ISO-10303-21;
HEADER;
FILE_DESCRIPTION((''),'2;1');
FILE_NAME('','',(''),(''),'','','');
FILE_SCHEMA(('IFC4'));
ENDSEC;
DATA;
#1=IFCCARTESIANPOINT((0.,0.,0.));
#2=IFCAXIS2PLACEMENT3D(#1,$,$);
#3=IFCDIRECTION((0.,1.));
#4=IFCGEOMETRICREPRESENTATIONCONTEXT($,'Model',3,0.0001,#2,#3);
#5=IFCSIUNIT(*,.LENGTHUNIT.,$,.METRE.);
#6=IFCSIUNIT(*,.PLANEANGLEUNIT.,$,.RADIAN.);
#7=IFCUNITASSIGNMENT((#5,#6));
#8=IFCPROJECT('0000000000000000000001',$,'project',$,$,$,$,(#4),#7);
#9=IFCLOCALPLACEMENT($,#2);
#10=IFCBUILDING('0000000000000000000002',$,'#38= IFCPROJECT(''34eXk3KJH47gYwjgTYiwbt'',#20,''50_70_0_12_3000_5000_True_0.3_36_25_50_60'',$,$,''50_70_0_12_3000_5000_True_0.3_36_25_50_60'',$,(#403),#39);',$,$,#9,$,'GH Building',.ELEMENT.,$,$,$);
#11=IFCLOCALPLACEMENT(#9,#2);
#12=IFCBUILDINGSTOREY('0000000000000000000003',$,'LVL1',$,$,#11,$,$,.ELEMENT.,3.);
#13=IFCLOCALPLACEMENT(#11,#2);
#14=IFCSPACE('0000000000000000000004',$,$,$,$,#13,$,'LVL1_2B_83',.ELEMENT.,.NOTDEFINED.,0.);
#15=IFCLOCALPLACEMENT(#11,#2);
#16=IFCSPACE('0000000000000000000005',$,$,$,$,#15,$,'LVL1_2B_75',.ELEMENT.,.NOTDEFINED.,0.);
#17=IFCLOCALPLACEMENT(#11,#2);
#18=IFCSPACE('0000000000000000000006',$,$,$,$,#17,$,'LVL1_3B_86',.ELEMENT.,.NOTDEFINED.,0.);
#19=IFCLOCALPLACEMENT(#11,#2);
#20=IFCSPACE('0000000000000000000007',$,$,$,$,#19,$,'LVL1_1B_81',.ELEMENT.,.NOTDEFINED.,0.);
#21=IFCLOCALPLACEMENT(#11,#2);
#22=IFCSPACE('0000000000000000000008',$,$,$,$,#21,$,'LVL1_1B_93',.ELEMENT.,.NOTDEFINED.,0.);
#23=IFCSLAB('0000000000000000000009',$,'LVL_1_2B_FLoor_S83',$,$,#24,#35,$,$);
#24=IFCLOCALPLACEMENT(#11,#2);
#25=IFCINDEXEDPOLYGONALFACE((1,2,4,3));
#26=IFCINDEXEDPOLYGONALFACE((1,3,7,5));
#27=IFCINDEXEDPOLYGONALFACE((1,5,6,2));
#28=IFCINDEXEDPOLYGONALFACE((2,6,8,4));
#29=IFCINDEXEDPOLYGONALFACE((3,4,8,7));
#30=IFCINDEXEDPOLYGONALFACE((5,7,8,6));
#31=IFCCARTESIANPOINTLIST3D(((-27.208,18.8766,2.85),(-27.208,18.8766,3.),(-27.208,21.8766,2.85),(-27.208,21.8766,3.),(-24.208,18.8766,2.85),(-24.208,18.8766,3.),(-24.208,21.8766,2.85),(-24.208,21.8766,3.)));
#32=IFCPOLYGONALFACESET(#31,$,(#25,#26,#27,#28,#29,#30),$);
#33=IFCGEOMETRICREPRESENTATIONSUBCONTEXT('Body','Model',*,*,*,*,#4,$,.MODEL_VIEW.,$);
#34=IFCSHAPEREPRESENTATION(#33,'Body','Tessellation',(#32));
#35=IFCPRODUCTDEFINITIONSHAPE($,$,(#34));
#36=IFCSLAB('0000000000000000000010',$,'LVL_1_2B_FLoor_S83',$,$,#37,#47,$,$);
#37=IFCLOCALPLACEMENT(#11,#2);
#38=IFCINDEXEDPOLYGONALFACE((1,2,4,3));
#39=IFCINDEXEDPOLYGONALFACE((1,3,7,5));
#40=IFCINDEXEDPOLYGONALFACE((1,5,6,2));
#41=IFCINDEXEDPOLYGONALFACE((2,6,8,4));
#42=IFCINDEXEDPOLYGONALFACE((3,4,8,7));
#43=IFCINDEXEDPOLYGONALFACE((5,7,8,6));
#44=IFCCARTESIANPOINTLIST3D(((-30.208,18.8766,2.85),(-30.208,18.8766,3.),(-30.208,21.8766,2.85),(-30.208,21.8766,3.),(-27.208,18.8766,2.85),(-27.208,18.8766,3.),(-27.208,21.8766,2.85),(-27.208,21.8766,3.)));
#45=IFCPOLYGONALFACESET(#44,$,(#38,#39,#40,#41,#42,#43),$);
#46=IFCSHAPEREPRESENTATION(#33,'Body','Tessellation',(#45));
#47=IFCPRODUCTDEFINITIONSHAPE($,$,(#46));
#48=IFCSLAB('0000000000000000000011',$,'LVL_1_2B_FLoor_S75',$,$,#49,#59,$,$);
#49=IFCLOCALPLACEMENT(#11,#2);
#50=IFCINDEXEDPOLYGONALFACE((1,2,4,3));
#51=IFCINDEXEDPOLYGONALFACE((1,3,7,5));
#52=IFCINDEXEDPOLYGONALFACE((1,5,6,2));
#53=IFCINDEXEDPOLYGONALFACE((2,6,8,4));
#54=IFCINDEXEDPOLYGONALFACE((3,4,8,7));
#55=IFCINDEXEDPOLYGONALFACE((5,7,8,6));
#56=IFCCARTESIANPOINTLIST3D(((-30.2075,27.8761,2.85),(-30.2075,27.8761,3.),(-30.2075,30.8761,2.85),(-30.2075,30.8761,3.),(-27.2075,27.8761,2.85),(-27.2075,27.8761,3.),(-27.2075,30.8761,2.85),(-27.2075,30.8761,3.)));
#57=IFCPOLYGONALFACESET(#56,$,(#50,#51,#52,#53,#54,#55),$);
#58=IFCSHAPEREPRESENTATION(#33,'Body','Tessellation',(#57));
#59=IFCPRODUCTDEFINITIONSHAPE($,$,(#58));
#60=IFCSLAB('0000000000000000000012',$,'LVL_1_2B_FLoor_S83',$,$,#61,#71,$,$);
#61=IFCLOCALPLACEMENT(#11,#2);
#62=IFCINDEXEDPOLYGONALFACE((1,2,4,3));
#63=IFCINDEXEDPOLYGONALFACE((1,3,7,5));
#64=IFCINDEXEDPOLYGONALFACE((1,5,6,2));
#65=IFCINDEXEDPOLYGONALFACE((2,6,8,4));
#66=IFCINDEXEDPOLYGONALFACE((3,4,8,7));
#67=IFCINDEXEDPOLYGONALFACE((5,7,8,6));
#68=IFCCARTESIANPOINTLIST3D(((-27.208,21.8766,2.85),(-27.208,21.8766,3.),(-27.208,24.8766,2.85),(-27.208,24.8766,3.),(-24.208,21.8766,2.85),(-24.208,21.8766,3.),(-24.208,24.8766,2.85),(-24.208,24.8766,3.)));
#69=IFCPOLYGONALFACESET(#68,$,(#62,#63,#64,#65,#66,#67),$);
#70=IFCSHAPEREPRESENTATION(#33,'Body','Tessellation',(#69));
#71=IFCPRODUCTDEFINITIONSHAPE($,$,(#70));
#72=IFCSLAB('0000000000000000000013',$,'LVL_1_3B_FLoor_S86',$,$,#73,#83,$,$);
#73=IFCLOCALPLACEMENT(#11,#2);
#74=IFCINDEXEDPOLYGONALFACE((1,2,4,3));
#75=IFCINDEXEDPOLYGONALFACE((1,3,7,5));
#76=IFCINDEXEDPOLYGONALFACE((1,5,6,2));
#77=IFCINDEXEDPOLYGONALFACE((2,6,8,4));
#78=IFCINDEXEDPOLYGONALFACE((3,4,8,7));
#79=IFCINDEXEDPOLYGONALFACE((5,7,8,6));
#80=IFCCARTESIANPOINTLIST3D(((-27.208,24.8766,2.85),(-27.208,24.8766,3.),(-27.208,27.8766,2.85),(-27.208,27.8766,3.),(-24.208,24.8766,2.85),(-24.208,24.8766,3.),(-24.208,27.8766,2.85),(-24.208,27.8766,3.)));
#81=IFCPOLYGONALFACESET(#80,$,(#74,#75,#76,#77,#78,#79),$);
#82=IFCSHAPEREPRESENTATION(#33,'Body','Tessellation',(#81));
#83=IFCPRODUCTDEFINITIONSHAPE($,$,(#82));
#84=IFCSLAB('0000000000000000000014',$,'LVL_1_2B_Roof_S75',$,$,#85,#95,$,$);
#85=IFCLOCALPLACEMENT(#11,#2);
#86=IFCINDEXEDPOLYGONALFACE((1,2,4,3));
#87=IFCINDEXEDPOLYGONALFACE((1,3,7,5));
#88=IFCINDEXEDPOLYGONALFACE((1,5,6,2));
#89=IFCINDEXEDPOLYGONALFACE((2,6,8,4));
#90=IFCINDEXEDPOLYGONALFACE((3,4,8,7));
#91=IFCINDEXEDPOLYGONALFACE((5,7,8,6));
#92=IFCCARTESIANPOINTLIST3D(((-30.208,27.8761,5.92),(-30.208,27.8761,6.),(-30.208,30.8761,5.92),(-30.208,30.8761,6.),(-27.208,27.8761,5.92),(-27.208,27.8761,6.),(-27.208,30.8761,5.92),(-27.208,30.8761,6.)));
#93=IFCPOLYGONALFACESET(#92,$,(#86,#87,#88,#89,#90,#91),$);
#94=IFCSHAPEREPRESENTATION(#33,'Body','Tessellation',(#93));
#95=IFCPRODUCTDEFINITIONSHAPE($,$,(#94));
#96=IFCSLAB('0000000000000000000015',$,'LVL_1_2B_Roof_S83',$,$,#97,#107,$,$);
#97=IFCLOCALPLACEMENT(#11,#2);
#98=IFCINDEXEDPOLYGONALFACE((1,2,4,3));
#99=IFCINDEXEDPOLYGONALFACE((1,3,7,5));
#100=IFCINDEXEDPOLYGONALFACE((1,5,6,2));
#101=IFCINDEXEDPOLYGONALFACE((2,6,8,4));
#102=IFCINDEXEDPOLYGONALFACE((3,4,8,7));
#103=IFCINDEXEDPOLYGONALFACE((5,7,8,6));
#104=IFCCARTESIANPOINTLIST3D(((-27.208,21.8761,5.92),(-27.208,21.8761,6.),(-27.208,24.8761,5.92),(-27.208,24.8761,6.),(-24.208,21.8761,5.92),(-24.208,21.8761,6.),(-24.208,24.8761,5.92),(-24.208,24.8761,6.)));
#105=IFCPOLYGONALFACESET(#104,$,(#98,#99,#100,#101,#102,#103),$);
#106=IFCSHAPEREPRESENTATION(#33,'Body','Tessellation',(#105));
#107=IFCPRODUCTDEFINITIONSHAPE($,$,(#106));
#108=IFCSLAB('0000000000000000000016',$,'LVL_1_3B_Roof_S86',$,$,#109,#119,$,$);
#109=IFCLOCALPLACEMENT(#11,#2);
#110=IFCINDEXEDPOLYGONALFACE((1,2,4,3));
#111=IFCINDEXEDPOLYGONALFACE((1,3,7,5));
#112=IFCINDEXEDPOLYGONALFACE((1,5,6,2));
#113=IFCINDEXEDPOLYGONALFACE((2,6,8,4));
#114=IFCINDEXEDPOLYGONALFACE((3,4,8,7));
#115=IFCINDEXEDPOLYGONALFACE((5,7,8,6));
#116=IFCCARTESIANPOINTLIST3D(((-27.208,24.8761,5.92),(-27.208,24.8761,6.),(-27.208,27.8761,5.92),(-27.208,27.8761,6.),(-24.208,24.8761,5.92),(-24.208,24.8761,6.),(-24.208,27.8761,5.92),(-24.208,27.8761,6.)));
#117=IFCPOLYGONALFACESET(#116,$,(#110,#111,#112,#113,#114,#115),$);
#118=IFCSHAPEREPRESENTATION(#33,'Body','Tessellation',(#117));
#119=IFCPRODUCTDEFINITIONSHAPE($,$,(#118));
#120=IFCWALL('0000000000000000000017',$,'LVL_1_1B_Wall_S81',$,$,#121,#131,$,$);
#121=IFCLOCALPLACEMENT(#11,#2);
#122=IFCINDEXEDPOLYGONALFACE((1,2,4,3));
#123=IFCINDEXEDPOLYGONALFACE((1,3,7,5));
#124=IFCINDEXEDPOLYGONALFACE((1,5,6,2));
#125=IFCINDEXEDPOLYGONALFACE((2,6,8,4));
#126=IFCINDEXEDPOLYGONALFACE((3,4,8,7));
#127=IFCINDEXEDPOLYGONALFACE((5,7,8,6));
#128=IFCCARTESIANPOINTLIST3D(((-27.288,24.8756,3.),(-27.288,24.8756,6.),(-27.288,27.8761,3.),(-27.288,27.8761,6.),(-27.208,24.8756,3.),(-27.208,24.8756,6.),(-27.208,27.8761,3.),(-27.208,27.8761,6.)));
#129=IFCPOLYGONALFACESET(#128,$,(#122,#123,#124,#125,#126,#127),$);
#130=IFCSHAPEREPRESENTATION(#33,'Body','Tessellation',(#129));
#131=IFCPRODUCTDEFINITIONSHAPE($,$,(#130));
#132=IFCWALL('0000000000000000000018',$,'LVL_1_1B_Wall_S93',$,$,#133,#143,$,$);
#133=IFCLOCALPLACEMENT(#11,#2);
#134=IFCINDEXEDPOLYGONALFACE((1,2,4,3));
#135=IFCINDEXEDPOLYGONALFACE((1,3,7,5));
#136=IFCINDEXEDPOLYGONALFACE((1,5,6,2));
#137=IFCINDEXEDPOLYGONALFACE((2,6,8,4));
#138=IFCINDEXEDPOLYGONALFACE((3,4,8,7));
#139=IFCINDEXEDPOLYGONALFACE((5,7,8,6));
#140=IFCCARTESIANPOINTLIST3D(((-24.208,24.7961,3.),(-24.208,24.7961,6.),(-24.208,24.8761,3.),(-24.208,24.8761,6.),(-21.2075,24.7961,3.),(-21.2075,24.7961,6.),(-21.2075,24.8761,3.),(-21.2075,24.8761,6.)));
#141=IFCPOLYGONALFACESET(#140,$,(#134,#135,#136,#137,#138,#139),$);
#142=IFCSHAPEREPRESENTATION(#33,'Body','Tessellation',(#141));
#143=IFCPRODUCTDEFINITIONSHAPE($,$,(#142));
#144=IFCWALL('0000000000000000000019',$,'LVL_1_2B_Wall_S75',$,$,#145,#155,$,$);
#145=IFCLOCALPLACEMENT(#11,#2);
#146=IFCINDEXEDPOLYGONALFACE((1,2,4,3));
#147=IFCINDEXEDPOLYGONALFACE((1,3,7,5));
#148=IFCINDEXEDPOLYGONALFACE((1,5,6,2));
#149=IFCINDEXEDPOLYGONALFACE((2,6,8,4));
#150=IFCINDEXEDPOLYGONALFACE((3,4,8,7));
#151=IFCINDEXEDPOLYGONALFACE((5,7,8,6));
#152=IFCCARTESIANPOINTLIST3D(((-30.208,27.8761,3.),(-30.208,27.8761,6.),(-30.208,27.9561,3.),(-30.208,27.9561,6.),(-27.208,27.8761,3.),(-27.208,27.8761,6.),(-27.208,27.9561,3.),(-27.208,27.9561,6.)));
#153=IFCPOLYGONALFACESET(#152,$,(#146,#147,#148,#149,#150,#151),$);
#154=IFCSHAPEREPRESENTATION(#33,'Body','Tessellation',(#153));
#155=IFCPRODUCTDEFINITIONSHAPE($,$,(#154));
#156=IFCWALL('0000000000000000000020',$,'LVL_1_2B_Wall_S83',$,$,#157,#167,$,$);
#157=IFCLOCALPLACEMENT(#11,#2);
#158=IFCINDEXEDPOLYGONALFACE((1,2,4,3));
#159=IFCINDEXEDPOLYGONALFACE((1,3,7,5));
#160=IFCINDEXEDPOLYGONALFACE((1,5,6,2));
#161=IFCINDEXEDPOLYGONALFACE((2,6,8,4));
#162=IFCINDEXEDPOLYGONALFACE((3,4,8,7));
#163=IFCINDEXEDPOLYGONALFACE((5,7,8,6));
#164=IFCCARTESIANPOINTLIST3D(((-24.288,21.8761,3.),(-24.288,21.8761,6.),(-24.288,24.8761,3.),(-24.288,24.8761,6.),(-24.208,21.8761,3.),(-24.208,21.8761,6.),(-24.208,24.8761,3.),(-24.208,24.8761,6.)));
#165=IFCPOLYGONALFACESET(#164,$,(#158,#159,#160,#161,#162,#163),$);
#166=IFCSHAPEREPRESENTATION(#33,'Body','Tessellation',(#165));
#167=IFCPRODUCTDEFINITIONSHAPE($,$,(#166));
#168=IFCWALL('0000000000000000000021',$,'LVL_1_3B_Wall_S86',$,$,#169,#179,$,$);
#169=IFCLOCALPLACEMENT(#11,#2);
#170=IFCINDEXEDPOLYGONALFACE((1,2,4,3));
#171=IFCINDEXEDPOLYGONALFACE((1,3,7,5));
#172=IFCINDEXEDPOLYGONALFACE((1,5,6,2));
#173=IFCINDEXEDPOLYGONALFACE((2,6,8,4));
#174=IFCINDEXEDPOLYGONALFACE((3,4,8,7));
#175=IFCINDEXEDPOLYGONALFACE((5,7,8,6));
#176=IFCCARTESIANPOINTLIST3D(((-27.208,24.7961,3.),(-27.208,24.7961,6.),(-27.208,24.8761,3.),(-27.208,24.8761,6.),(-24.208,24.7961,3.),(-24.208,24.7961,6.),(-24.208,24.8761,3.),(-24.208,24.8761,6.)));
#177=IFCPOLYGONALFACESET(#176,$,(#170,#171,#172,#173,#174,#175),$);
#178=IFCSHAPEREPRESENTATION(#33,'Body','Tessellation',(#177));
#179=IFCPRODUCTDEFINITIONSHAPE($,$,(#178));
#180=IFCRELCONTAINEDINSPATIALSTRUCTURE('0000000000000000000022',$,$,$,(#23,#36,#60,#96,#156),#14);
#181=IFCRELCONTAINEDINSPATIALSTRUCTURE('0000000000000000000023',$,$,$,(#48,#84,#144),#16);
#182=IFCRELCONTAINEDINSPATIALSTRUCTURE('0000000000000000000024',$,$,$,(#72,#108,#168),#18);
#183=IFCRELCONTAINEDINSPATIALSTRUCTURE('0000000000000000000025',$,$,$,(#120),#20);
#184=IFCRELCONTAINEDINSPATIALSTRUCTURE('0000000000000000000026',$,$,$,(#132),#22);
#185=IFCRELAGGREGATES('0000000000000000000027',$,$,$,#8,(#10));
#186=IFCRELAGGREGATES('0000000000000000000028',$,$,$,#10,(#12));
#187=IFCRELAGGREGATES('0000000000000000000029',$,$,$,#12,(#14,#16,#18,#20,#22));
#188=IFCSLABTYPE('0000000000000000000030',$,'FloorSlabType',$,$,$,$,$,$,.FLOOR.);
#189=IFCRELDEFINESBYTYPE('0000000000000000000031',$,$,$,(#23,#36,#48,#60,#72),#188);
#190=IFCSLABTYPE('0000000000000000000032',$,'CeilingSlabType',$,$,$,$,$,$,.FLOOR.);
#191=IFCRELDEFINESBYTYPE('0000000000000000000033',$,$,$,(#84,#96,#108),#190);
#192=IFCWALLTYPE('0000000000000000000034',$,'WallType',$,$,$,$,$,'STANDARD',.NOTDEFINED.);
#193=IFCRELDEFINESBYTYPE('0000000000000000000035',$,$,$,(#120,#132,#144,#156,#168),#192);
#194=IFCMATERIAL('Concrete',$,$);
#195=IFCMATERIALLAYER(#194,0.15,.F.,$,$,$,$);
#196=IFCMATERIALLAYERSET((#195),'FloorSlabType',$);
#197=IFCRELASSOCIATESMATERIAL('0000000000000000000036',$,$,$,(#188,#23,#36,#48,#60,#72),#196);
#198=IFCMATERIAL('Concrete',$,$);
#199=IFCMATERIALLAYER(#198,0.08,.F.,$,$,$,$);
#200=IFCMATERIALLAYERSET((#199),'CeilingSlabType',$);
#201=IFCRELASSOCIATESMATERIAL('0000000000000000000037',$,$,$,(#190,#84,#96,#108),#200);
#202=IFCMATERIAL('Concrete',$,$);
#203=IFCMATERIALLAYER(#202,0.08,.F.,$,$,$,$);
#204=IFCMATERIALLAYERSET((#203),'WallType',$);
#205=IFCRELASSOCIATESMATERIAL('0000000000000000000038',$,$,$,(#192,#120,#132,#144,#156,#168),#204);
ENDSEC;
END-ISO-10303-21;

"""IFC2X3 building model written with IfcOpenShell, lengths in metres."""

from ifc_helpers import new_model, si_unit, direction, frame, frame_2d, origin, place, context, subcontext, project, spatial, rectangle, extrude, material, layer, layer_set, layer_usage, type_object, element, save


model = new_model("IFC2X3")

# Units and contexts
model_context = context("Model", 3, precision=0.0001, world=origin(), true_north=direction((0.0, 1.0)))
body_context = subcontext(model_context, "Body", "Model", "MODEL_VIEW")
ifc_project = project(units=[si_unit("LENGTHUNIT", "METRE"), si_unit("PLANEANGLEUNIT", "RADIAN")], contexts=[model_context])

# Building, storey, space
building_placement = place(None, origin())
building = spatial("IfcBuilding", under=ifc_project, at=building_placement, Name="#38= IFCPROJECT('34eXk3KJH47gYwjgTYiwbt',#20,'50_70_0_12_3000_5000_True_0.3_36_25_50_60',$,$,'50_70_0_12_3000_5000_True_0.3_36_25_50_60',$,(#403),#39);", LongName="GH Building", CompositionType="ELEMENT")
storey_placement = place(building_placement, origin())
storey = spatial("IfcBuildingStorey", under=building, at=storey_placement, Name="LVL1", CompositionType="ELEMENT", Elevation=3.0)
space_1_placement = place(storey_placement, origin())
space_1 = spatial("IfcSpace", under=storey, at=space_1_placement, LongName="LVL1_2B_83", CompositionType="ELEMENT", InteriorOrExteriorSpace="NOTDEFINED", ElevationWithFlooring=0.0)

# Slabs
ifc_material_1 = material(Name="Concrete")
ifc_layer_1 = layer(ifc_material_1, 0.15, ventilated=False)
ifc_layer_set_1 = layer_set([ifc_layer_1], Name="FloorSlabType")
ifc_layer_usage_1 = layer_usage(ifc_layer_set_1, "AXIS3", "NEGATIVE", -0.15)
slab_type_1 = type_object("IfcSlabType", Name="FloorSlabType", PredefinedType="FLOOR", material=ifc_layer_set_1)
slab_1_placement = place(space_1_placement, frame((-24.208, 21.8766, 2.85), z_axis=(0.0, 0.0, 1.0), x_axis=(-1.0, 0.0, 0.0)))
element("IfcSlab", 1, at=slab_1_placement, inside=space_1, type_object=slab_type_1, material=ifc_layer_usage_1, Name="LVL_1_2B_FLoor_S83", context=body_context, shape_type="SweptSolid", body=[
    extrude(rectangle(XDim=3.0, YDim=3.0, at=frame_2d((1.5, 1.5))), origin(), (0.0, 0.0, 1.0), 0.15),
])
ifc_layer_usage_2 = layer_usage(ifc_layer_set_1, "AXIS3", "NEGATIVE", -0.15)
slab_2_placement = place(space_1_placement, frame((-27.208, 21.8766, 2.85), z_axis=(0.0, 0.0, 1.0), x_axis=(-1.0, 0.0, 0.0)))
element("IfcSlab", 2, at=slab_2_placement, inside=space_1, type_object=slab_type_1, material=ifc_layer_usage_2, Name="LVL_1_2B_FLoor_S83", context=body_context, shape_type="SweptSolid", body=[
    extrude(rectangle(XDim=3.0, YDim=3.0, at=frame_2d((1.5, 1.5))), origin(), (0.0, 0.0, 1.0), 0.15),
])

# Shared definitions
space_2_placement = place(storey_placement, origin())
space_2 = spatial("IfcSpace", under=storey, at=space_2_placement, LongName="LVL1_2B_75", CompositionType="ELEMENT", InteriorOrExteriorSpace="NOTDEFINED", ElevationWithFlooring=0.0)

# Slabs
ifc_layer_usage_3 = layer_usage(ifc_layer_set_1, "AXIS3", "NEGATIVE", -0.15)
slab_3_placement = place(space_2_placement, frame((-27.2075, 27.8761, 2.85), z_axis=(0.0, 0.0, 1.0), x_axis=(0.0, 1.0, 0.0)))
element("IfcSlab", 3, at=slab_3_placement, inside=space_2, type_object=slab_type_1, material=ifc_layer_usage_3, Name="LVL_1_2B_FLoor_S75", context=body_context, shape_type="SweptSolid", body=[
    extrude(rectangle(XDim=3.0, YDim=3.0, at=frame_2d((1.5, 1.5))), origin(), (0.0, 0.0, 1.0), 0.15),
])
ifc_layer_usage_4 = layer_usage(ifc_layer_set_1, "AXIS3", "NEGATIVE", -0.15)
slab_4_placement = place(space_1_placement, frame((-24.208, 24.8766, 2.85), z_axis=(0.0, 0.0, 1.0), x_axis=(-1.0, 0.0, 0.0)))
element("IfcSlab", 4, at=slab_4_placement, inside=space_1, type_object=slab_type_1, material=ifc_layer_usage_4, Name="LVL_1_2B_FLoor_S83", context=body_context, shape_type="SweptSolid", body=[
    extrude(rectangle(XDim=3.0, YDim=3.0, at=frame_2d((1.5, 1.5))), origin(), (0.0, 0.0, 1.0), 0.15),
])

# Shared definitions
space_3_placement = place(storey_placement, origin())
space_3 = spatial("IfcSpace", under=storey, at=space_3_placement, LongName="LVL1_3B_86", CompositionType="ELEMENT", InteriorOrExteriorSpace="NOTDEFINED", ElevationWithFlooring=0.0)

# Slabs
ifc_layer_usage_5 = layer_usage(ifc_layer_set_1, "AXIS3", "NEGATIVE", -0.15)
slab_5_placement = place(space_3_placement, frame((-24.208, 27.8766, 2.85), z_axis=(0.0, 0.0, 1.0), x_axis=(-1.0, 0.0, 0.0)))
element("IfcSlab", 5, at=slab_5_placement, inside=space_3, type_object=slab_type_1, material=ifc_layer_usage_5, Name="LVL_1_3B_FLoor_S86", context=body_context, shape_type="SweptSolid", body=[
    extrude(rectangle(XDim=3.0, YDim=3.0, at=frame_2d((1.5, 1.5))), origin(), (0.0, 0.0, 1.0), 0.15),
])
ifc_material_2 = material(Name="Concrete")
ifc_layer_2 = layer(ifc_material_2, 0.08, ventilated=False)
ifc_layer_set_2 = layer_set([ifc_layer_2], Name="CeilingSlabType")
ifc_layer_usage_6 = layer_usage(ifc_layer_set_2, "AXIS3", "NEGATIVE", -0.08)
slab_type_2 = type_object("IfcSlabType", Name="CeilingSlabType", PredefinedType="FLOOR", material=ifc_layer_set_2)
slab_6_placement = place(space_2_placement, frame((-27.208, 27.8761, 5.92), z_axis=(0.0, 0.0, 1.0), x_axis=(0.0, 1.0, 0.0)))
element("IfcSlab", 6, at=slab_6_placement, inside=space_2, type_object=slab_type_2, material=ifc_layer_usage_6, Name="LVL_1_2B_Roof_S75", context=body_context, shape_type="SweptSolid", body=[
    extrude(rectangle(XDim=3.0, YDim=3.0, at=frame_2d((1.5, 1.5))), origin(), (0.0, 0.0, 1.0), 0.08),
])
ifc_layer_usage_7 = layer_usage(ifc_layer_set_2, "AXIS3", "NEGATIVE", -0.08)
slab_7_placement = place(space_1_placement, frame((-24.208, 24.8761, 5.92), z_axis=(0.0, 0.0, 1.0), x_axis=(-1.0, 0.0, 0.0)))
element("IfcSlab", 7, at=slab_7_placement, inside=space_1, type_object=slab_type_2, material=ifc_layer_usage_7, Name="LVL_1_2B_Roof_S83", context=body_context, shape_type="SweptSolid", body=[
    extrude(rectangle(XDim=3.0, YDim=3.0, at=frame_2d((1.5, 1.5))), origin(), (0.0, 0.0, 1.0), 0.08),
])
ifc_layer_usage_8 = layer_usage(ifc_layer_set_2, "AXIS3", "NEGATIVE", -0.08)
slab_8_placement = place(space_3_placement, frame((-27.208, 27.8761, 5.92)))
element("IfcSlab", 8, at=slab_8_placement, inside=space_3, type_object=slab_type_2, material=ifc_layer_usage_8, Name="LVL_1_3B_Roof_S86", context=body_context, shape_type="SweptSolid", body=[
    extrude(rectangle(XDim=3.0, YDim=3.0, at=frame_2d((1.5, -1.5))), origin(), (0.0, 0.0, 1.0), 0.08),
])

# Shared definitions
space_4_placement = place(storey_placement, origin())
space_4 = spatial("IfcSpace", under=storey, at=space_4_placement, LongName="LVL1_1B_81", CompositionType="ELEMENT", InteriorOrExteriorSpace="NOTDEFINED", ElevationWithFlooring=0.0)

# Shared definitions
ifc_material_3 = material(Name="Concrete")
ifc_layer_3 = layer(ifc_material_3, 0.08, ventilated=False)
ifc_layer_set_3 = layer_set([ifc_layer_3], Name="WallType")
wall_type_1 = type_object("IfcWallType", Name="WallType", ElementType="STANDARD", PredefinedType="NOTDEFINED", material=ifc_layer_set_3)

# Wall
ifc_layer_usage_9 = layer_usage(ifc_layer_set_3, "AXIS2", "NEGATIVE", 0.0)
wall_1_placement = place(space_4_placement, frame((-27.208, 27.8761, 3.0), z_axis=(0.0, 0.0, 1.0), x_axis=(0.0, -1.0, 0.0)))
element("IfcWall", 9, at=wall_1_placement, inside=space_4, type_object=wall_type_1, material=ifc_layer_usage_9, Name="LVL_1_1B_Wall_S81", context=body_context, shape_type="SweptSolid", body=[
    extrude(rectangle(XDim=3.0005, YDim=0.08, at=frame_2d((1.5003, -0.04))), origin(), (0.0, 0.0, 1.0), 3.0),
])

# Shared definitions
space_5_placement = place(storey_placement, origin())
space_5 = spatial("IfcSpace", under=storey, at=space_5_placement, LongName="LVL1_1B_93", CompositionType="ELEMENT", InteriorOrExteriorSpace="NOTDEFINED", ElevationWithFlooring=0.0)

# Walls
ifc_layer_usage_10 = layer_usage(ifc_layer_set_3, "AXIS2", "NEGATIVE", 0.0)
wall_2_placement = place(space_5_placement, frame((-24.208, 24.8761, 3.0)))
element("IfcWall", 10, at=wall_2_placement, inside=space_5, type_object=wall_type_1, material=ifc_layer_usage_10, Name="LVL_1_1B_Wall_S93", context=body_context, shape_type="SweptSolid", body=[
    extrude(rectangle(XDim=3.0005, YDim=0.08, at=frame_2d((1.5003, -0.04))), origin(), (0.0, 0.0, 1.0), 3.0),
])
ifc_layer_usage_11 = layer_usage(ifc_layer_set_3, "AXIS2", "NEGATIVE", 0.0)
wall_3_placement = place(space_2_placement, frame((-27.208, 27.8761, 3.0), z_axis=(0.0, 0.0, 1.0), x_axis=(-1.0, 0.0, 0.0)))
element("IfcWall", 11, at=wall_3_placement, inside=space_2, type_object=wall_type_1, material=ifc_layer_usage_11, Name="LVL_1_2B_Wall_S75", context=body_context, shape_type="SweptSolid", body=[
    extrude(rectangle(XDim=3.0, YDim=0.08, at=frame_2d((1.5, -0.04))), origin(), (0.0, 0.0, 1.0), 3.0),
])
ifc_layer_usage_12 = layer_usage(ifc_layer_set_3, "AXIS2", "NEGATIVE", 0.0)
wall_4_placement = place(space_1_placement, frame((-24.208, 24.8761, 3.0), z_axis=(0.0, 0.0, 1.0), x_axis=(0.0, -1.0, 0.0)))
element("IfcWall", 12, at=wall_4_placement, inside=space_1, type_object=wall_type_1, material=ifc_layer_usage_12, Name="LVL_1_2B_Wall_S83", context=body_context, shape_type="SweptSolid", body=[
    extrude(rectangle(XDim=3.0, YDim=0.08, at=frame_2d((1.5, -0.04))), origin(), (0.0, 0.0, 1.0), 3.0),
])

# Wall
ifc_layer_usage_13 = layer_usage(ifc_layer_set_3, "AXIS2", "NEGATIVE", 0.0)
wall_5_placement = place(space_3_placement, frame((-27.208, 24.8761, 3.0)))
element("IfcWall", 13, at=wall_5_placement, inside=space_3, type_object=wall_type_1, material=ifc_layer_usage_13, Name="LVL_1_3B_Wall_S86", context=body_context, shape_type="SweptSolid", body=[
    extrude(rectangle(XDim=3.0, YDim=0.08, at=frame_2d((1.5, -0.04))), origin(), (0.0, 0.0, 1.0), 3.0),
])

save(model, "model.ifc")
